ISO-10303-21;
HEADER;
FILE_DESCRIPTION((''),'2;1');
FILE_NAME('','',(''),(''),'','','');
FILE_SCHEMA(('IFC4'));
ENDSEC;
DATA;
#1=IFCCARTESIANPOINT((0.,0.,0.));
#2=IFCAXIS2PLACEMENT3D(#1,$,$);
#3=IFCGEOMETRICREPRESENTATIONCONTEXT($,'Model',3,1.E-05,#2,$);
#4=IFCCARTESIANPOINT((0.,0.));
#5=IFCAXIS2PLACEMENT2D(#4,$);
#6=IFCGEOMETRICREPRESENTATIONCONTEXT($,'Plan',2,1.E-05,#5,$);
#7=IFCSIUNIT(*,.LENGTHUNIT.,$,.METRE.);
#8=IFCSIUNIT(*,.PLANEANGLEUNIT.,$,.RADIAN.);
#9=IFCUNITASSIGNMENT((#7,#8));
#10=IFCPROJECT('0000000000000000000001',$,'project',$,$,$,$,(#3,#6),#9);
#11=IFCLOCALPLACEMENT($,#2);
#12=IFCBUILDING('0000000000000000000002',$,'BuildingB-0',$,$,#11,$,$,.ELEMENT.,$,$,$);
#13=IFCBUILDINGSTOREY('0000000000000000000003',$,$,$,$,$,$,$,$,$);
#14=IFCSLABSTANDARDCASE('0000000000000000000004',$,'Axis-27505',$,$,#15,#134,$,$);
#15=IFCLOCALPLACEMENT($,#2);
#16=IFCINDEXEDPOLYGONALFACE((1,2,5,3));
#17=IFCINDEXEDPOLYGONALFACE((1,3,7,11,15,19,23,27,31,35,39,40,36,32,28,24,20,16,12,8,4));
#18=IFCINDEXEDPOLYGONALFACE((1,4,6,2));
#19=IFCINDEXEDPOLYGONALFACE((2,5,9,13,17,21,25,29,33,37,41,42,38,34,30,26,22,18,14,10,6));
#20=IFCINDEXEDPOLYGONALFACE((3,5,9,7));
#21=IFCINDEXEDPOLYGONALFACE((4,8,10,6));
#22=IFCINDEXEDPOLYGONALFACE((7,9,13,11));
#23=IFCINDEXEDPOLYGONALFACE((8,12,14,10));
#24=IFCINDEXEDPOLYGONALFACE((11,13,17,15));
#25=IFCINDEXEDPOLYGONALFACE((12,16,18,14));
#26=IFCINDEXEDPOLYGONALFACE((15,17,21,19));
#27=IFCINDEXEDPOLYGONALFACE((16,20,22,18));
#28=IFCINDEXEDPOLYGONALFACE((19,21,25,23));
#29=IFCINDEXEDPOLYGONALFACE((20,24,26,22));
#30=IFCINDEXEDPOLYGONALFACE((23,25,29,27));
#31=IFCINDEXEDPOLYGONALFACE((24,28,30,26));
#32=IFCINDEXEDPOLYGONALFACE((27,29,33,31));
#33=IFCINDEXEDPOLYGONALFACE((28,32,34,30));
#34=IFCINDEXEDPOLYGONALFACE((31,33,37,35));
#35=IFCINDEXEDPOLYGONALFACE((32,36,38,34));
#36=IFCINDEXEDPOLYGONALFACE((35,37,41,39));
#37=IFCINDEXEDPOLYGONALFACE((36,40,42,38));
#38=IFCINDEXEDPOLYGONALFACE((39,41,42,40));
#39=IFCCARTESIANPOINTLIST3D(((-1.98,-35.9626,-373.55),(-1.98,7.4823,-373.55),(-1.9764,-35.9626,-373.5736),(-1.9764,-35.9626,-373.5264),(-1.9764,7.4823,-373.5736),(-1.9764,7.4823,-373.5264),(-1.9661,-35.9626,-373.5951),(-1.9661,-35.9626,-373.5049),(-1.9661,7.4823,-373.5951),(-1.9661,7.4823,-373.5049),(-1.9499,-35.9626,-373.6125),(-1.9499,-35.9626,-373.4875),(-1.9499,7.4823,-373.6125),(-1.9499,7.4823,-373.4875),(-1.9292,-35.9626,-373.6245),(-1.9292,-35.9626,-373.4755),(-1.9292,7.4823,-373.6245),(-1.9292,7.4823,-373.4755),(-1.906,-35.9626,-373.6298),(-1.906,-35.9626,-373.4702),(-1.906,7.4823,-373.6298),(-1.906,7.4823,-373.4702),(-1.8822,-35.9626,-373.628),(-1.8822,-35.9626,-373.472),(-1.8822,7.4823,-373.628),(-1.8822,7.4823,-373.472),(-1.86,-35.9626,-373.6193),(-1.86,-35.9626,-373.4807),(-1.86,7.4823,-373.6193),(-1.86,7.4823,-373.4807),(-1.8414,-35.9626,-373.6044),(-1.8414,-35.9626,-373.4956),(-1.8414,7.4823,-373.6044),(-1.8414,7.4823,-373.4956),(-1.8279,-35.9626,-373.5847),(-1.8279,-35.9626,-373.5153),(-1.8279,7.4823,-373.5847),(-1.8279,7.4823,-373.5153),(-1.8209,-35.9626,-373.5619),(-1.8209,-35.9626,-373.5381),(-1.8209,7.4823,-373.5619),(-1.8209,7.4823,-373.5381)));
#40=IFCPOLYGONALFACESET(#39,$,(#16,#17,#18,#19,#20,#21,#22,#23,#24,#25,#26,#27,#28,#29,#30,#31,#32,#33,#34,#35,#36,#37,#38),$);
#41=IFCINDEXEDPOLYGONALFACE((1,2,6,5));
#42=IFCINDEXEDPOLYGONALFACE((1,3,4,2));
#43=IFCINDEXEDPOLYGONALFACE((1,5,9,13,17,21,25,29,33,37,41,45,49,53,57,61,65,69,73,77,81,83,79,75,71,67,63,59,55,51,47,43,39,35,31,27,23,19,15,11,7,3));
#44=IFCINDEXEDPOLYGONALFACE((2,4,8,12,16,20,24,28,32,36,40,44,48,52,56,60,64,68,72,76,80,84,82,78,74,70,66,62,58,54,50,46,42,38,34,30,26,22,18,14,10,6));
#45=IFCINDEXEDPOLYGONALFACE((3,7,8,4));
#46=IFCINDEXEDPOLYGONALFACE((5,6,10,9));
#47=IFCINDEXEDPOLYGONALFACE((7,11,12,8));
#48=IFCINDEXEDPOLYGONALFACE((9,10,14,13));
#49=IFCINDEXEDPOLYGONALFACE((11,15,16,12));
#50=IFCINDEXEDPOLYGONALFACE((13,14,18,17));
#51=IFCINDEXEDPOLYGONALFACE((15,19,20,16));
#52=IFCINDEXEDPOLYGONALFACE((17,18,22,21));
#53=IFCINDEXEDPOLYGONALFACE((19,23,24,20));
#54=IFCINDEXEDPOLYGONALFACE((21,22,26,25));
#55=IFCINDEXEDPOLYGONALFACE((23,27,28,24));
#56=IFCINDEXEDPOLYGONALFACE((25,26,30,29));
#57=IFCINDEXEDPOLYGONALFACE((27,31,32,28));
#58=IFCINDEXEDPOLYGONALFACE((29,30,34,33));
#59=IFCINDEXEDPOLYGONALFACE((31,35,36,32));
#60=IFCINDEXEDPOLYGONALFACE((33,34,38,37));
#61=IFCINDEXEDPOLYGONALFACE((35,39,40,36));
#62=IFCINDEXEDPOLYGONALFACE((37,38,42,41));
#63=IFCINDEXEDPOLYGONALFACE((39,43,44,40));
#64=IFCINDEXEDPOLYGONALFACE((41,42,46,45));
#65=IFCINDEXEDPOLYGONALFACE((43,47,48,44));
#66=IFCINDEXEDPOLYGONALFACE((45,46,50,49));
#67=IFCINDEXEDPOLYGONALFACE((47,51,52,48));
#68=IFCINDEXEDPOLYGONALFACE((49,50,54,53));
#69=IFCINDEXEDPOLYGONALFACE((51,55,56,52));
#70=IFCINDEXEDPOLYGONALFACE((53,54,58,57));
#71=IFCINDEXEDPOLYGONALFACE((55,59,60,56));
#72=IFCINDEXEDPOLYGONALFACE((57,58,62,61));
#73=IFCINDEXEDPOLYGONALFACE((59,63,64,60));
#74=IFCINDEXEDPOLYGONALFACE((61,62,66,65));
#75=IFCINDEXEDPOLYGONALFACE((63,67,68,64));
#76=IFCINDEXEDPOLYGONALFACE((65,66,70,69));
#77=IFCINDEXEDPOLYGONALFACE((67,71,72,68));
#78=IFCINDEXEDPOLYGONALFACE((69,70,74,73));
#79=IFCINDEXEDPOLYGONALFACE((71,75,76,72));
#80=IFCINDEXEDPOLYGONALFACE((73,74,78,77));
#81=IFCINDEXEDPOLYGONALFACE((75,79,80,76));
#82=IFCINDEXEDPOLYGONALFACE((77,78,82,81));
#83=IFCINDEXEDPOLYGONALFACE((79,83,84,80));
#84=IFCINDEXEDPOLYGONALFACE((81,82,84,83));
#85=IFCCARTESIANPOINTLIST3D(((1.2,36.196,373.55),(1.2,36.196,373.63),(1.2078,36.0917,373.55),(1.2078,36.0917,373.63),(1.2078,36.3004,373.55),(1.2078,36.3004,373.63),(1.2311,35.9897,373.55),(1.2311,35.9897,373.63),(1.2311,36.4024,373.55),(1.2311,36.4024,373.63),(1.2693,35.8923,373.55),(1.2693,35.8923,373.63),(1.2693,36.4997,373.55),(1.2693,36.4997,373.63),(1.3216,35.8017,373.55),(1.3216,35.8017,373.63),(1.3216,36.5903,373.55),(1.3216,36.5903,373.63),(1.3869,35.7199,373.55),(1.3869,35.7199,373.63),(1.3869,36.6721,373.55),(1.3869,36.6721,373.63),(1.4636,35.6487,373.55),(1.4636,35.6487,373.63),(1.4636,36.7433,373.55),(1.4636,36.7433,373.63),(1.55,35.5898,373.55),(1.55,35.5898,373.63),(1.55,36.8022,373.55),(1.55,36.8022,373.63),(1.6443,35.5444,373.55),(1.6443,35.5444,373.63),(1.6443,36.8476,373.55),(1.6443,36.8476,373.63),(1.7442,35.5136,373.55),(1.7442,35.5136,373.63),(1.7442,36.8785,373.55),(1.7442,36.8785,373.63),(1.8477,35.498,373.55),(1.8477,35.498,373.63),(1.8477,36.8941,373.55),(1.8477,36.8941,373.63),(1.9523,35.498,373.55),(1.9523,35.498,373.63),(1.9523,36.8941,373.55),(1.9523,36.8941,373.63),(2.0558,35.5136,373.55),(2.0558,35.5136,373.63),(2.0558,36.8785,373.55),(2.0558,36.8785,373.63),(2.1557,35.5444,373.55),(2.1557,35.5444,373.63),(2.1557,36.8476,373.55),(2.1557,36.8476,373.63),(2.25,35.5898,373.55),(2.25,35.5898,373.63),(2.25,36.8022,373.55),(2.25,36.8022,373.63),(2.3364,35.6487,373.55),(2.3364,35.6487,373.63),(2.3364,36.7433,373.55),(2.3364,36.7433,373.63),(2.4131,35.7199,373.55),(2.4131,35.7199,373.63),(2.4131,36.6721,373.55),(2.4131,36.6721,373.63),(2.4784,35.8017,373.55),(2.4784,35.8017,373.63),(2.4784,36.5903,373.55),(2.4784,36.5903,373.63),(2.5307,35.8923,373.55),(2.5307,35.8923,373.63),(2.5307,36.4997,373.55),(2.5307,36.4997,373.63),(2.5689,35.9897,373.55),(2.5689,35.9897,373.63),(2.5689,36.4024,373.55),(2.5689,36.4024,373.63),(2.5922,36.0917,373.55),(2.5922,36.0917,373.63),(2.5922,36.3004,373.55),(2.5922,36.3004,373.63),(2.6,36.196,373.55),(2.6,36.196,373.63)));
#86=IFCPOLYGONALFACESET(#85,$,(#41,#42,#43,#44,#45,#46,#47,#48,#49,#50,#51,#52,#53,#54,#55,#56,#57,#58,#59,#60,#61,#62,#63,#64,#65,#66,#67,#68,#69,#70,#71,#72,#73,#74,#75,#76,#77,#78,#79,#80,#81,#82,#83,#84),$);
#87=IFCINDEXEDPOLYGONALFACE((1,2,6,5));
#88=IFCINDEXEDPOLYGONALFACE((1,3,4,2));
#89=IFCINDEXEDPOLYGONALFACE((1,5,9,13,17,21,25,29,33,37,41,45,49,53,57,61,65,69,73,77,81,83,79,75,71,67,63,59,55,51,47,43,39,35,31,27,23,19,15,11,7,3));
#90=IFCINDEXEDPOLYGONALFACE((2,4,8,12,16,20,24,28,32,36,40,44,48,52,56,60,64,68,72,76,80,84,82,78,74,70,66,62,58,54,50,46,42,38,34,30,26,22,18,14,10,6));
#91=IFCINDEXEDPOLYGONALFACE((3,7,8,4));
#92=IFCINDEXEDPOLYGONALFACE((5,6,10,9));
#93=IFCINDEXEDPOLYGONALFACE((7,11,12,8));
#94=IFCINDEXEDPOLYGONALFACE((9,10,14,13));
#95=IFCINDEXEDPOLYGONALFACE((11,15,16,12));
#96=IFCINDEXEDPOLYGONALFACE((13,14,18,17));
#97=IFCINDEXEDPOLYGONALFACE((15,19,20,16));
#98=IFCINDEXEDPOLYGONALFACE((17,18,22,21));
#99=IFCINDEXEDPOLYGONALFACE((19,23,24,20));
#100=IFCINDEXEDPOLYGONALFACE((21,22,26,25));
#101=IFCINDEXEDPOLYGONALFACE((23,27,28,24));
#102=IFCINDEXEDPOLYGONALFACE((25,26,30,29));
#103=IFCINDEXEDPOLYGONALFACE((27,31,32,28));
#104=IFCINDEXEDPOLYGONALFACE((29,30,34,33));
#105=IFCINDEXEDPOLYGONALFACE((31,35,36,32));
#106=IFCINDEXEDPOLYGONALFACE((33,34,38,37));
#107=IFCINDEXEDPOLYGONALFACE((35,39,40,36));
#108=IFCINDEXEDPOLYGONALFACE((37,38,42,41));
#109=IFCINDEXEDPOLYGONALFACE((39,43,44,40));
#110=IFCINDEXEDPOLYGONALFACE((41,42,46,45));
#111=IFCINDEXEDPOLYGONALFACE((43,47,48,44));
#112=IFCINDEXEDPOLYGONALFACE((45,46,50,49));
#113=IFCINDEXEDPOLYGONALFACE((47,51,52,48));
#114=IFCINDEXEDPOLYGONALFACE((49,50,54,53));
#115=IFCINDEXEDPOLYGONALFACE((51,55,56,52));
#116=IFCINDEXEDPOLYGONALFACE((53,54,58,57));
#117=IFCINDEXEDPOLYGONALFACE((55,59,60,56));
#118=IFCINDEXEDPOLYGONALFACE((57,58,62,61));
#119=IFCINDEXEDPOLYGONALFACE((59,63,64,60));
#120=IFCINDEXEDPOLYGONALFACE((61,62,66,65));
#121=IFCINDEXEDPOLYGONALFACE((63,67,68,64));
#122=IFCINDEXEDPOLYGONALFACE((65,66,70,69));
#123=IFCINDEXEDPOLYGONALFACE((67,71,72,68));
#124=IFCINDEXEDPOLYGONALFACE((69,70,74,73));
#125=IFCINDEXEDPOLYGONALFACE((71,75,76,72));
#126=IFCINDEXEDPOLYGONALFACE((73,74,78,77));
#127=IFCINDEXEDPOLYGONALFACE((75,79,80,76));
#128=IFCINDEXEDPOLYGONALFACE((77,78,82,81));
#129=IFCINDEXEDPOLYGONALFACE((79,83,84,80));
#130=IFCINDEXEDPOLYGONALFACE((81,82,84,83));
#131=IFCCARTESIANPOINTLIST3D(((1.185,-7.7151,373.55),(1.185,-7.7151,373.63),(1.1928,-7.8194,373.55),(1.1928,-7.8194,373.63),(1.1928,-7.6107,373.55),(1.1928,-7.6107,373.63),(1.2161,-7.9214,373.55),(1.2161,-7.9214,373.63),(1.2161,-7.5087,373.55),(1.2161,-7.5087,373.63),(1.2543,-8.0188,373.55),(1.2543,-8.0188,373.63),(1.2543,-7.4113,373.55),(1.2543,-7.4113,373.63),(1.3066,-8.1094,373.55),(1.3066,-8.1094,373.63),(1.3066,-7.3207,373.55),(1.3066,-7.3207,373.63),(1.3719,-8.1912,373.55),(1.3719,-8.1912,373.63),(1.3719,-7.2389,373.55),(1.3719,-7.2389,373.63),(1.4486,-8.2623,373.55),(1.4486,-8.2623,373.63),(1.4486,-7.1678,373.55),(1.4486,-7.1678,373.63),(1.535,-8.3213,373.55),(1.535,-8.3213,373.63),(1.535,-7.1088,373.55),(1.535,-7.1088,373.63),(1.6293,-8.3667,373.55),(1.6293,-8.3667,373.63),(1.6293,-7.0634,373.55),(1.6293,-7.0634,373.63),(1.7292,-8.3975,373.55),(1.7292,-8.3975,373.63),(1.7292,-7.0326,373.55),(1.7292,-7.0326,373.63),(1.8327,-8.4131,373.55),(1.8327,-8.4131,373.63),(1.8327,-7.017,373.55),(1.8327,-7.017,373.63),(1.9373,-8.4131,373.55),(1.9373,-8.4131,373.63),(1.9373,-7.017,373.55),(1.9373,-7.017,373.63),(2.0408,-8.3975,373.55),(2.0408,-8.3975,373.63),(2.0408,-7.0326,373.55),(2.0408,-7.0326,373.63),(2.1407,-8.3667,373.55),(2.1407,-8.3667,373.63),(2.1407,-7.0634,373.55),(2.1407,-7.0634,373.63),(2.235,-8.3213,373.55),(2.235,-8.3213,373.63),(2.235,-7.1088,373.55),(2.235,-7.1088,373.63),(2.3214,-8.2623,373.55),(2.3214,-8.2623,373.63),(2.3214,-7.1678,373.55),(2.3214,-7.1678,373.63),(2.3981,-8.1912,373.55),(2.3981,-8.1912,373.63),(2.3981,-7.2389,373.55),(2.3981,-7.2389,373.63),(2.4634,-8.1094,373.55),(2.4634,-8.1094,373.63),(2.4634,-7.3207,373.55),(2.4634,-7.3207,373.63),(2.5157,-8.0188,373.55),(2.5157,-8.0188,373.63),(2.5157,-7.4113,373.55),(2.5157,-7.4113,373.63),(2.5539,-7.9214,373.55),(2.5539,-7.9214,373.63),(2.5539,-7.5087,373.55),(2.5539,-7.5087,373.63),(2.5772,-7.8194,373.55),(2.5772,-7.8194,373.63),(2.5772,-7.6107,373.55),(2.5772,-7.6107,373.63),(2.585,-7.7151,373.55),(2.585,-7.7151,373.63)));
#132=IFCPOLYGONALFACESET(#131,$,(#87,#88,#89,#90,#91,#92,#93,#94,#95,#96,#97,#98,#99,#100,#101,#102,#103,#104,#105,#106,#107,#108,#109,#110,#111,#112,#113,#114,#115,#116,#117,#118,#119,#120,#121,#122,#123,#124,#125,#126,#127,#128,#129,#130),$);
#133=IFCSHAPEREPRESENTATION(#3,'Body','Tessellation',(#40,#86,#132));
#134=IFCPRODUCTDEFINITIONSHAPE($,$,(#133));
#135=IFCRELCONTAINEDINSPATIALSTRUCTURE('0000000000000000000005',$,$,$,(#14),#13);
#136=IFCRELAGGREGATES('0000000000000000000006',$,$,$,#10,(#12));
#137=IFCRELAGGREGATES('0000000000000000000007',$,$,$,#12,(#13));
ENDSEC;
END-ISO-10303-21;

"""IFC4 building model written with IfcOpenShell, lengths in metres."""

from ifc_helpers import new_model, entity, si_unit, frame, origin, origin_2d, place, context, project, spatial, circle, extrude, element, save


model = new_model("IFC4")

# Units and contexts
model_context = context("Model", 3, precision=1e-05, world=origin())
plan_context = context("Plan", 2, precision=1e-05, world=origin_2d())
ifc_project = project(units=[si_unit("LENGTHUNIT", "METRE"), si_unit("PLANEANGLEUNIT", "RADIAN")], contexts=[model_context, plan_context])

# Building, storey
building_placement = place(None, origin())
building = spatial("IfcBuilding", under=ifc_project, at=building_placement, Name="BuildingB-0", CompositionType="ELEMENT")
storey = spatial("IfcBuildingStorey", under=building)

# Slab
element("IfcSlabStandardCase", 1, inside=storey, Name="Axis-27505", context=model_context, shape_type="AdvancedSweptSolid", body=[
    entity("IfcSurfaceCurveSweptAreaSolid", entity("IfcCircleProfileDef", "AREA", None, None, 0.08), None, entity("IfcPolyline", [entity("IfcCartesianPoint", [1.9, 35.9626, 373.55]), entity("IfcCartesianPoint", [1.9, -7.4823, 373.55])]), None, None, entity("IfcPlane", entity("IfcAxis2Placement3D", entity("IfcCartesianPoint", [1.9, 35.9626, 373.55]), entity("IfcDirection", [0.0, 0.0, 1.0]), entity("IfcDirection", [1.0, 0.0, 0.0])))),
    extrude(circle(Radius=0.7), frame((1.9, 36.196, 373.55)), (0.0, 0.0, 1.0), 0.08),
    extrude(circle(Radius=0.7), frame((1.885, -7.7151, 373.55)), (0.0, 0.0, 1.0), 0.08),
])

save(model, "model.ifc")
